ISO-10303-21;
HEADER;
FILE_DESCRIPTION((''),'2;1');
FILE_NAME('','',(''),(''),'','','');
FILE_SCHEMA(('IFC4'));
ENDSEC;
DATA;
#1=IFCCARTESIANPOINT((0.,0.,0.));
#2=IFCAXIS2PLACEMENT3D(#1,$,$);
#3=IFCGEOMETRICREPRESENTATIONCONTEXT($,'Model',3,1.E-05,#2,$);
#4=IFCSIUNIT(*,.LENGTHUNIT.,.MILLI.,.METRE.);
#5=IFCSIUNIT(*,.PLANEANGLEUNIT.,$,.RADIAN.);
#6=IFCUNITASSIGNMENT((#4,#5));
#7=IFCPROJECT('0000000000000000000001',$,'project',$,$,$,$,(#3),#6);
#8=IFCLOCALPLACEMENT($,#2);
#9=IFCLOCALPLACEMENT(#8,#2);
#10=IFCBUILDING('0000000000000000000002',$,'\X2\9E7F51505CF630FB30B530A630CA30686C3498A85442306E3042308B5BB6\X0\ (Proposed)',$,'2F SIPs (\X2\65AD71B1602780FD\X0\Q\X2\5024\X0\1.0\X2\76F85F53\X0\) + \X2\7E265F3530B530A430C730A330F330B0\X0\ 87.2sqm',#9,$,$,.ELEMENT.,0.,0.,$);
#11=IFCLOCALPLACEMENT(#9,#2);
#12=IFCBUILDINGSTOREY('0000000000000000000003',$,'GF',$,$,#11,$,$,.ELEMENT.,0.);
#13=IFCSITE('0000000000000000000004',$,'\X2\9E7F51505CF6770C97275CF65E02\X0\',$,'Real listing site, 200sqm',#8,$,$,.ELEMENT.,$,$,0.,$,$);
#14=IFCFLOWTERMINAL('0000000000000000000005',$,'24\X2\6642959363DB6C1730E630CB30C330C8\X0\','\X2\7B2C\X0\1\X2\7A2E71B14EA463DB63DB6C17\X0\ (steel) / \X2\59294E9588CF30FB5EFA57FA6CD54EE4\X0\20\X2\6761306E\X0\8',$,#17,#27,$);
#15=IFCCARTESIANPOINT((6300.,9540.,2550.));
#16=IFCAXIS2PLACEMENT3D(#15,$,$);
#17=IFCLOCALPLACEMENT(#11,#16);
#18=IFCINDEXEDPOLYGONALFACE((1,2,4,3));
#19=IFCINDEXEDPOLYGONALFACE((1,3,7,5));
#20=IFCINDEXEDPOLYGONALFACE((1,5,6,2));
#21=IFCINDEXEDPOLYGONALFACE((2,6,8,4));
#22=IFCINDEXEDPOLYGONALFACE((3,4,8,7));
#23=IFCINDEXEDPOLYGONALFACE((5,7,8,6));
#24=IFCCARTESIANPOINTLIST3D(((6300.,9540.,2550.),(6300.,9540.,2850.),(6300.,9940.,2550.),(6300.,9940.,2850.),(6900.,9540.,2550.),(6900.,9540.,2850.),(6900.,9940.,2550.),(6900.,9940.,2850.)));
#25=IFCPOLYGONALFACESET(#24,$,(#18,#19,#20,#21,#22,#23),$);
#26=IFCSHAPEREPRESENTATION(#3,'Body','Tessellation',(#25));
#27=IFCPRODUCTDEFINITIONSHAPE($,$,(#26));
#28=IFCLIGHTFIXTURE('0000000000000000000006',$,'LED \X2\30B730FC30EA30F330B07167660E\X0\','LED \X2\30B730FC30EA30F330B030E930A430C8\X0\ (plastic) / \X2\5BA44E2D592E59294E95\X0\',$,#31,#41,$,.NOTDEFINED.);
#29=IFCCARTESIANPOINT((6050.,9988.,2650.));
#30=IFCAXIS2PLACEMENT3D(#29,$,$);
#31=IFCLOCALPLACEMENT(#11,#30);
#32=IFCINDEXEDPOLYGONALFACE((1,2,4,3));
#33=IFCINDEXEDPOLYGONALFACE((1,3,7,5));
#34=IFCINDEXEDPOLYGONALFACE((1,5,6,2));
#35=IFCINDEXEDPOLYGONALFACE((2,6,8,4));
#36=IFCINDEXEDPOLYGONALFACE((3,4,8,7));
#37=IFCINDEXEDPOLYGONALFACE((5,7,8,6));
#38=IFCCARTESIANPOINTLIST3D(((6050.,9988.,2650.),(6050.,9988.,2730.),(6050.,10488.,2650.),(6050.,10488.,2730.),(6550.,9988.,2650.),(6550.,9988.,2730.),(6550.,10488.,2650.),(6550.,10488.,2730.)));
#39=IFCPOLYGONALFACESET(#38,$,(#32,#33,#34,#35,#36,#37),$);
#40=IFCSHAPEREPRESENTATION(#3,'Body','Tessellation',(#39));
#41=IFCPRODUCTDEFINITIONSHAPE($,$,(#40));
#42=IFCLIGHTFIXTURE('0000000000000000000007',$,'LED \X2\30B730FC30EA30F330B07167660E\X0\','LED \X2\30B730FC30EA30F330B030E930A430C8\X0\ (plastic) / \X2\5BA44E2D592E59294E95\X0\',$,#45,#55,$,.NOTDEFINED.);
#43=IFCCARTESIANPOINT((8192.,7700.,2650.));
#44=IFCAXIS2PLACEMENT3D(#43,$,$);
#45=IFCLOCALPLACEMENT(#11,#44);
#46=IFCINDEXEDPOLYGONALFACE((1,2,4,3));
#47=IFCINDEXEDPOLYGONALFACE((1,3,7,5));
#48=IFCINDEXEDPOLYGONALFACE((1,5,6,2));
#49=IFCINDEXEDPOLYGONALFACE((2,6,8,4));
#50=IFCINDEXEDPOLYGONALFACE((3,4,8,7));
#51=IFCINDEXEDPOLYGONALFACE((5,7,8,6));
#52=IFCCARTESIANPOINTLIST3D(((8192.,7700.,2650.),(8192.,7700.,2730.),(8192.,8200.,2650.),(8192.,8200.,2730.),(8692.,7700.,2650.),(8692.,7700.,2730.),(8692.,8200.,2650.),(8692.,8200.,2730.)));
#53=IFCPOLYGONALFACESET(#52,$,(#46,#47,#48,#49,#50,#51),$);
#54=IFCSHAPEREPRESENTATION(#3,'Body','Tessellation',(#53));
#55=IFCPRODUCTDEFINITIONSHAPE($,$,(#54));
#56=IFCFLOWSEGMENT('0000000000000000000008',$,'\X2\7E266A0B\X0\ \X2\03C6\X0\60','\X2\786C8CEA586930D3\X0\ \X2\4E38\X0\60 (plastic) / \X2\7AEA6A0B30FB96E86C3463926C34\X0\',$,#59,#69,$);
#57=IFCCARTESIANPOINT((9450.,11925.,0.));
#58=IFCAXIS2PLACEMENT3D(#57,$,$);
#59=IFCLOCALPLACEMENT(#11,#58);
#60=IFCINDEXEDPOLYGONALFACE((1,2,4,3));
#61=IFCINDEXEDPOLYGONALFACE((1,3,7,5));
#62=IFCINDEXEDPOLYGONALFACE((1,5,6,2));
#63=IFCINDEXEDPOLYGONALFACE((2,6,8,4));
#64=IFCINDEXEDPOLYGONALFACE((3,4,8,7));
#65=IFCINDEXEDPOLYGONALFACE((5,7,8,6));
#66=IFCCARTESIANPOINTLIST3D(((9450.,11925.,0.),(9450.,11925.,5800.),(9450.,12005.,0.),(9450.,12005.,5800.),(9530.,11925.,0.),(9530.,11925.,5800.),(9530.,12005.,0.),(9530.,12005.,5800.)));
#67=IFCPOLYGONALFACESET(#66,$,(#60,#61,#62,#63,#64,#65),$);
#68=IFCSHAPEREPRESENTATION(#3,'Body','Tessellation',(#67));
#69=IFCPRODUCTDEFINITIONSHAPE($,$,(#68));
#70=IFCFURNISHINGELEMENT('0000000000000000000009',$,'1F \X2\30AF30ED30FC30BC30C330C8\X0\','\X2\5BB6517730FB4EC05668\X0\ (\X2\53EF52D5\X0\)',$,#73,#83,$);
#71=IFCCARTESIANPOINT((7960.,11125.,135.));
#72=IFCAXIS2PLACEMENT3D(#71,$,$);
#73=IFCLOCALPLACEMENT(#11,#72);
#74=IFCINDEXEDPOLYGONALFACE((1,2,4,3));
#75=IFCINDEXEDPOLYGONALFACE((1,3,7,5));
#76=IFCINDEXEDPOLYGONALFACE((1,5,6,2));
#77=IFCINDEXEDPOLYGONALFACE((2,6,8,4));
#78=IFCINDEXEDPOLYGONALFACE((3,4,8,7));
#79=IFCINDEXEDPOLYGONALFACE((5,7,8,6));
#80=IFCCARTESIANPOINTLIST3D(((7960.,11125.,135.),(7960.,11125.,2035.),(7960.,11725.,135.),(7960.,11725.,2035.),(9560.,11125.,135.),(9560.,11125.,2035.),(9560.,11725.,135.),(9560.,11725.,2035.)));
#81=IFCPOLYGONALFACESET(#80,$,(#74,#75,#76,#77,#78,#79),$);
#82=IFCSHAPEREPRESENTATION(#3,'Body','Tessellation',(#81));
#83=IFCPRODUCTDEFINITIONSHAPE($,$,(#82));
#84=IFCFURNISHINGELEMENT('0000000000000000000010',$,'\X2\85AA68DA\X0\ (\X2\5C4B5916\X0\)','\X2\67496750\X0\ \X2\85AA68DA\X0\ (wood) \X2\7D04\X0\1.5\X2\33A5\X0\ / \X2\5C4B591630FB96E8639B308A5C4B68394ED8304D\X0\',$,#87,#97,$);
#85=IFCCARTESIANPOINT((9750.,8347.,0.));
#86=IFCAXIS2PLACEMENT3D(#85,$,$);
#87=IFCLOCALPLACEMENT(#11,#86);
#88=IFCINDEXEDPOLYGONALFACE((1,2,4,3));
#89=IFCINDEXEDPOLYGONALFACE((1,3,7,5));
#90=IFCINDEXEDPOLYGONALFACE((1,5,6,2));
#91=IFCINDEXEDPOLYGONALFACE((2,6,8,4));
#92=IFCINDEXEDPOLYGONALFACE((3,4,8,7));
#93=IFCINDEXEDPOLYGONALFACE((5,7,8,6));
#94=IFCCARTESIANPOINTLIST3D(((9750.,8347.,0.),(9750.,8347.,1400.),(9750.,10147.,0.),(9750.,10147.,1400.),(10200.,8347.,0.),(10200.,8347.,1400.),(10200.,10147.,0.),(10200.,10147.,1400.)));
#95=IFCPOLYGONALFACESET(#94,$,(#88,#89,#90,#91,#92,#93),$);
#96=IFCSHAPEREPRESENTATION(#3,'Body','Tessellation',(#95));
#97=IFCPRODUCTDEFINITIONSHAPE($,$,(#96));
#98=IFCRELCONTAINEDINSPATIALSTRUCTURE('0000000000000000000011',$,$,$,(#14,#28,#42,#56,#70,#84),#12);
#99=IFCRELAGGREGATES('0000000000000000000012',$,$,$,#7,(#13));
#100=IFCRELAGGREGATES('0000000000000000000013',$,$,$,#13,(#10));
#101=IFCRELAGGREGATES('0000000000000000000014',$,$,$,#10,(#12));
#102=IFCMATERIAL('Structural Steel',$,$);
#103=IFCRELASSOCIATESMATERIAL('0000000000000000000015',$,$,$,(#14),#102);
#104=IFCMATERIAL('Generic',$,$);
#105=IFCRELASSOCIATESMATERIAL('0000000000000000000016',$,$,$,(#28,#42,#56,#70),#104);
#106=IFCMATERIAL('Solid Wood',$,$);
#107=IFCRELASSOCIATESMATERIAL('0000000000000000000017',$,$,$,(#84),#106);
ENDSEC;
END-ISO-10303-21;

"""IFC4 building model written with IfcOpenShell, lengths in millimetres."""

from ifc_helpers import new_model, si_unit, frame, frame_2d, origin, place, context, project, spatial, rectangle, extrude, material, element, save


model = new_model("IFC4")

# Units and contexts
model_context = context("Model", 3, precision=1e-05, world=origin())
ifc_project = project(units=[si_unit("LENGTHUNIT", "METRE", prefix="MILLI"), si_unit("PLANEANGLEUNIT", "RADIAN")], contexts=[model_context])

# Site, building, storey
site_placement = place(None, origin())
site = spatial("IfcSite", under=ifc_project, at=site_placement, Name="鹿児島県霧島市", ObjectType="Real listing site, 200sqm", CompositionType="ELEMENT", RefElevation=0.0)
building_placement = place(site_placement, origin())
building = spatial("IfcBuilding", under=site, at=building_placement, Name="鹿児島・サウナと水風呂のある家 (Proposed)", ObjectType="2F SIPs (断熱性能Q値1.0相当) + 縦張サイディング 87.2sqm", CompositionType="ELEMENT", ElevationOfRefHeight=0.0, ElevationOfTerrain=0.0)
storey_placement = place(building_placement, origin())
storey = spatial("IfcBuildingStorey", under=building, at=storey_placement, Name="GF", CompositionType="ELEMENT", Elevation=0.0)

# Shared definitions
ifc_material_1 = material(Name="Solid Wood")

# Shared definitions
ifc_material_2 = material(Name="Generic")

# Flow terminal
ifc_material_3 = material(Name="Structural Steel")
flow_terminal_placement = place(storey_placement, frame((6300.0, 9540.0, 2550.0)))
element("IfcFlowTerminal", 1, at=flow_terminal_placement, inside=storey, material=ifc_material_3, Name="24時間換気ユニット", Description="第1種熱交換換気 (steel) / 天井裏・建基法令20条の8", context=model_context, shape_type="SweptSolid", body=[
    extrude(rectangle(XDim=600.0, YDim=400.0, at=frame_2d((300.0, 200.0))), frame((6300.0, 9540.0, 2550.0)), (0.0, 0.0, 1.0), 300.0),
])

# Light fixtures
light_fixture_1_placement = place(storey_placement, frame((6050.0, 9988.0, 2650.0)))
element("IfcLightFixture", 2, at=light_fixture_1_placement, inside=storey, material=ifc_material_2, Name="LED シーリング照明", Description="LED シーリングライト (plastic) / 室中央天井", PredefinedType="NOTDEFINED", context=model_context, shape_type="SweptSolid", body=[
    extrude(rectangle(XDim=500.0, YDim=500.0, at=frame_2d((250.0, 250.0))), frame((6050.0, 9988.0, 2650.0)), (0.0, 0.0, 1.0), 80.0),
])
light_fixture_2_placement = place(storey_placement, frame((8192.0, 7700.0, 2650.0)))
element("IfcLightFixture", 3, at=light_fixture_2_placement, inside=storey, material=ifc_material_2, Name="LED シーリング照明", Description="LED シーリングライト (plastic) / 室中央天井", PredefinedType="NOTDEFINED", context=model_context, shape_type="SweptSolid", body=[
    extrude(rectangle(XDim=500.0, YDim=500.0, at=frame_2d((250.0, 250.0))), frame((8192.0, 7700.0, 2650.0)), (0.0, 0.0, 1.0), 80.0),
])

# Flow segment
flow_segment_placement = place(storey_placement, frame((9450.0, 11925.0, 0.0)))
element("IfcFlowSegment", 4, at=flow_segment_placement, inside=storey, material=ifc_material_2, Name="縦樋 φ60", Description="硬質塩ビ 丸60 (plastic) / 竪樋・雨水排水", context=model_context, shape_type="SweptSolid", body=[
    extrude(rectangle(XDim=80.0, YDim=80.0, at=frame_2d((40.0, 40.0))), frame((9450.0, 11925.0, 0.0)), (0.0, 0.0, 1.0), 5800.0),
])

# Furnishing elements
furnishing_1_placement = place(storey_placement, frame((7960.0, 11125.0, 135.0)))
element("IfcFurnishingElement", 5, at=furnishing_1_placement, inside=storey, material=ifc_material_2, Name="1F クローゼット", Description="家具・什器 (可動)", context=model_context, shape_type="SweptSolid", body=[
    extrude(rectangle(XDim=1600.0, YDim=600.0, at=frame_2d((800.0, 300.0))), frame((7960.0, 11125.0, 135.0)), (0.0, 0.0, 1.0), 1900.0),
])
furnishing_2_placement = place(storey_placement, frame((9750.0, 8347.0, 0.0)))
element("IfcFurnishingElement", 6, at=furnishing_2_placement, inside=storey, material=ifc_material_1, Name="薪棚 (屋外)", Description="杉材 薪棚 (wood) 約1.5㎥ / 屋外・雨掛り屋根付き", context=model_context, shape_type="SweptSolid", body=[
    extrude(rectangle(XDim=450.0, YDim=1800.0, at=frame_2d((225.0, 900.0))), frame((9750.0, 8347.0, 0.0)), (0.0, 0.0, 1.0), 1400.0),
])

save(model, "model.ifc")
